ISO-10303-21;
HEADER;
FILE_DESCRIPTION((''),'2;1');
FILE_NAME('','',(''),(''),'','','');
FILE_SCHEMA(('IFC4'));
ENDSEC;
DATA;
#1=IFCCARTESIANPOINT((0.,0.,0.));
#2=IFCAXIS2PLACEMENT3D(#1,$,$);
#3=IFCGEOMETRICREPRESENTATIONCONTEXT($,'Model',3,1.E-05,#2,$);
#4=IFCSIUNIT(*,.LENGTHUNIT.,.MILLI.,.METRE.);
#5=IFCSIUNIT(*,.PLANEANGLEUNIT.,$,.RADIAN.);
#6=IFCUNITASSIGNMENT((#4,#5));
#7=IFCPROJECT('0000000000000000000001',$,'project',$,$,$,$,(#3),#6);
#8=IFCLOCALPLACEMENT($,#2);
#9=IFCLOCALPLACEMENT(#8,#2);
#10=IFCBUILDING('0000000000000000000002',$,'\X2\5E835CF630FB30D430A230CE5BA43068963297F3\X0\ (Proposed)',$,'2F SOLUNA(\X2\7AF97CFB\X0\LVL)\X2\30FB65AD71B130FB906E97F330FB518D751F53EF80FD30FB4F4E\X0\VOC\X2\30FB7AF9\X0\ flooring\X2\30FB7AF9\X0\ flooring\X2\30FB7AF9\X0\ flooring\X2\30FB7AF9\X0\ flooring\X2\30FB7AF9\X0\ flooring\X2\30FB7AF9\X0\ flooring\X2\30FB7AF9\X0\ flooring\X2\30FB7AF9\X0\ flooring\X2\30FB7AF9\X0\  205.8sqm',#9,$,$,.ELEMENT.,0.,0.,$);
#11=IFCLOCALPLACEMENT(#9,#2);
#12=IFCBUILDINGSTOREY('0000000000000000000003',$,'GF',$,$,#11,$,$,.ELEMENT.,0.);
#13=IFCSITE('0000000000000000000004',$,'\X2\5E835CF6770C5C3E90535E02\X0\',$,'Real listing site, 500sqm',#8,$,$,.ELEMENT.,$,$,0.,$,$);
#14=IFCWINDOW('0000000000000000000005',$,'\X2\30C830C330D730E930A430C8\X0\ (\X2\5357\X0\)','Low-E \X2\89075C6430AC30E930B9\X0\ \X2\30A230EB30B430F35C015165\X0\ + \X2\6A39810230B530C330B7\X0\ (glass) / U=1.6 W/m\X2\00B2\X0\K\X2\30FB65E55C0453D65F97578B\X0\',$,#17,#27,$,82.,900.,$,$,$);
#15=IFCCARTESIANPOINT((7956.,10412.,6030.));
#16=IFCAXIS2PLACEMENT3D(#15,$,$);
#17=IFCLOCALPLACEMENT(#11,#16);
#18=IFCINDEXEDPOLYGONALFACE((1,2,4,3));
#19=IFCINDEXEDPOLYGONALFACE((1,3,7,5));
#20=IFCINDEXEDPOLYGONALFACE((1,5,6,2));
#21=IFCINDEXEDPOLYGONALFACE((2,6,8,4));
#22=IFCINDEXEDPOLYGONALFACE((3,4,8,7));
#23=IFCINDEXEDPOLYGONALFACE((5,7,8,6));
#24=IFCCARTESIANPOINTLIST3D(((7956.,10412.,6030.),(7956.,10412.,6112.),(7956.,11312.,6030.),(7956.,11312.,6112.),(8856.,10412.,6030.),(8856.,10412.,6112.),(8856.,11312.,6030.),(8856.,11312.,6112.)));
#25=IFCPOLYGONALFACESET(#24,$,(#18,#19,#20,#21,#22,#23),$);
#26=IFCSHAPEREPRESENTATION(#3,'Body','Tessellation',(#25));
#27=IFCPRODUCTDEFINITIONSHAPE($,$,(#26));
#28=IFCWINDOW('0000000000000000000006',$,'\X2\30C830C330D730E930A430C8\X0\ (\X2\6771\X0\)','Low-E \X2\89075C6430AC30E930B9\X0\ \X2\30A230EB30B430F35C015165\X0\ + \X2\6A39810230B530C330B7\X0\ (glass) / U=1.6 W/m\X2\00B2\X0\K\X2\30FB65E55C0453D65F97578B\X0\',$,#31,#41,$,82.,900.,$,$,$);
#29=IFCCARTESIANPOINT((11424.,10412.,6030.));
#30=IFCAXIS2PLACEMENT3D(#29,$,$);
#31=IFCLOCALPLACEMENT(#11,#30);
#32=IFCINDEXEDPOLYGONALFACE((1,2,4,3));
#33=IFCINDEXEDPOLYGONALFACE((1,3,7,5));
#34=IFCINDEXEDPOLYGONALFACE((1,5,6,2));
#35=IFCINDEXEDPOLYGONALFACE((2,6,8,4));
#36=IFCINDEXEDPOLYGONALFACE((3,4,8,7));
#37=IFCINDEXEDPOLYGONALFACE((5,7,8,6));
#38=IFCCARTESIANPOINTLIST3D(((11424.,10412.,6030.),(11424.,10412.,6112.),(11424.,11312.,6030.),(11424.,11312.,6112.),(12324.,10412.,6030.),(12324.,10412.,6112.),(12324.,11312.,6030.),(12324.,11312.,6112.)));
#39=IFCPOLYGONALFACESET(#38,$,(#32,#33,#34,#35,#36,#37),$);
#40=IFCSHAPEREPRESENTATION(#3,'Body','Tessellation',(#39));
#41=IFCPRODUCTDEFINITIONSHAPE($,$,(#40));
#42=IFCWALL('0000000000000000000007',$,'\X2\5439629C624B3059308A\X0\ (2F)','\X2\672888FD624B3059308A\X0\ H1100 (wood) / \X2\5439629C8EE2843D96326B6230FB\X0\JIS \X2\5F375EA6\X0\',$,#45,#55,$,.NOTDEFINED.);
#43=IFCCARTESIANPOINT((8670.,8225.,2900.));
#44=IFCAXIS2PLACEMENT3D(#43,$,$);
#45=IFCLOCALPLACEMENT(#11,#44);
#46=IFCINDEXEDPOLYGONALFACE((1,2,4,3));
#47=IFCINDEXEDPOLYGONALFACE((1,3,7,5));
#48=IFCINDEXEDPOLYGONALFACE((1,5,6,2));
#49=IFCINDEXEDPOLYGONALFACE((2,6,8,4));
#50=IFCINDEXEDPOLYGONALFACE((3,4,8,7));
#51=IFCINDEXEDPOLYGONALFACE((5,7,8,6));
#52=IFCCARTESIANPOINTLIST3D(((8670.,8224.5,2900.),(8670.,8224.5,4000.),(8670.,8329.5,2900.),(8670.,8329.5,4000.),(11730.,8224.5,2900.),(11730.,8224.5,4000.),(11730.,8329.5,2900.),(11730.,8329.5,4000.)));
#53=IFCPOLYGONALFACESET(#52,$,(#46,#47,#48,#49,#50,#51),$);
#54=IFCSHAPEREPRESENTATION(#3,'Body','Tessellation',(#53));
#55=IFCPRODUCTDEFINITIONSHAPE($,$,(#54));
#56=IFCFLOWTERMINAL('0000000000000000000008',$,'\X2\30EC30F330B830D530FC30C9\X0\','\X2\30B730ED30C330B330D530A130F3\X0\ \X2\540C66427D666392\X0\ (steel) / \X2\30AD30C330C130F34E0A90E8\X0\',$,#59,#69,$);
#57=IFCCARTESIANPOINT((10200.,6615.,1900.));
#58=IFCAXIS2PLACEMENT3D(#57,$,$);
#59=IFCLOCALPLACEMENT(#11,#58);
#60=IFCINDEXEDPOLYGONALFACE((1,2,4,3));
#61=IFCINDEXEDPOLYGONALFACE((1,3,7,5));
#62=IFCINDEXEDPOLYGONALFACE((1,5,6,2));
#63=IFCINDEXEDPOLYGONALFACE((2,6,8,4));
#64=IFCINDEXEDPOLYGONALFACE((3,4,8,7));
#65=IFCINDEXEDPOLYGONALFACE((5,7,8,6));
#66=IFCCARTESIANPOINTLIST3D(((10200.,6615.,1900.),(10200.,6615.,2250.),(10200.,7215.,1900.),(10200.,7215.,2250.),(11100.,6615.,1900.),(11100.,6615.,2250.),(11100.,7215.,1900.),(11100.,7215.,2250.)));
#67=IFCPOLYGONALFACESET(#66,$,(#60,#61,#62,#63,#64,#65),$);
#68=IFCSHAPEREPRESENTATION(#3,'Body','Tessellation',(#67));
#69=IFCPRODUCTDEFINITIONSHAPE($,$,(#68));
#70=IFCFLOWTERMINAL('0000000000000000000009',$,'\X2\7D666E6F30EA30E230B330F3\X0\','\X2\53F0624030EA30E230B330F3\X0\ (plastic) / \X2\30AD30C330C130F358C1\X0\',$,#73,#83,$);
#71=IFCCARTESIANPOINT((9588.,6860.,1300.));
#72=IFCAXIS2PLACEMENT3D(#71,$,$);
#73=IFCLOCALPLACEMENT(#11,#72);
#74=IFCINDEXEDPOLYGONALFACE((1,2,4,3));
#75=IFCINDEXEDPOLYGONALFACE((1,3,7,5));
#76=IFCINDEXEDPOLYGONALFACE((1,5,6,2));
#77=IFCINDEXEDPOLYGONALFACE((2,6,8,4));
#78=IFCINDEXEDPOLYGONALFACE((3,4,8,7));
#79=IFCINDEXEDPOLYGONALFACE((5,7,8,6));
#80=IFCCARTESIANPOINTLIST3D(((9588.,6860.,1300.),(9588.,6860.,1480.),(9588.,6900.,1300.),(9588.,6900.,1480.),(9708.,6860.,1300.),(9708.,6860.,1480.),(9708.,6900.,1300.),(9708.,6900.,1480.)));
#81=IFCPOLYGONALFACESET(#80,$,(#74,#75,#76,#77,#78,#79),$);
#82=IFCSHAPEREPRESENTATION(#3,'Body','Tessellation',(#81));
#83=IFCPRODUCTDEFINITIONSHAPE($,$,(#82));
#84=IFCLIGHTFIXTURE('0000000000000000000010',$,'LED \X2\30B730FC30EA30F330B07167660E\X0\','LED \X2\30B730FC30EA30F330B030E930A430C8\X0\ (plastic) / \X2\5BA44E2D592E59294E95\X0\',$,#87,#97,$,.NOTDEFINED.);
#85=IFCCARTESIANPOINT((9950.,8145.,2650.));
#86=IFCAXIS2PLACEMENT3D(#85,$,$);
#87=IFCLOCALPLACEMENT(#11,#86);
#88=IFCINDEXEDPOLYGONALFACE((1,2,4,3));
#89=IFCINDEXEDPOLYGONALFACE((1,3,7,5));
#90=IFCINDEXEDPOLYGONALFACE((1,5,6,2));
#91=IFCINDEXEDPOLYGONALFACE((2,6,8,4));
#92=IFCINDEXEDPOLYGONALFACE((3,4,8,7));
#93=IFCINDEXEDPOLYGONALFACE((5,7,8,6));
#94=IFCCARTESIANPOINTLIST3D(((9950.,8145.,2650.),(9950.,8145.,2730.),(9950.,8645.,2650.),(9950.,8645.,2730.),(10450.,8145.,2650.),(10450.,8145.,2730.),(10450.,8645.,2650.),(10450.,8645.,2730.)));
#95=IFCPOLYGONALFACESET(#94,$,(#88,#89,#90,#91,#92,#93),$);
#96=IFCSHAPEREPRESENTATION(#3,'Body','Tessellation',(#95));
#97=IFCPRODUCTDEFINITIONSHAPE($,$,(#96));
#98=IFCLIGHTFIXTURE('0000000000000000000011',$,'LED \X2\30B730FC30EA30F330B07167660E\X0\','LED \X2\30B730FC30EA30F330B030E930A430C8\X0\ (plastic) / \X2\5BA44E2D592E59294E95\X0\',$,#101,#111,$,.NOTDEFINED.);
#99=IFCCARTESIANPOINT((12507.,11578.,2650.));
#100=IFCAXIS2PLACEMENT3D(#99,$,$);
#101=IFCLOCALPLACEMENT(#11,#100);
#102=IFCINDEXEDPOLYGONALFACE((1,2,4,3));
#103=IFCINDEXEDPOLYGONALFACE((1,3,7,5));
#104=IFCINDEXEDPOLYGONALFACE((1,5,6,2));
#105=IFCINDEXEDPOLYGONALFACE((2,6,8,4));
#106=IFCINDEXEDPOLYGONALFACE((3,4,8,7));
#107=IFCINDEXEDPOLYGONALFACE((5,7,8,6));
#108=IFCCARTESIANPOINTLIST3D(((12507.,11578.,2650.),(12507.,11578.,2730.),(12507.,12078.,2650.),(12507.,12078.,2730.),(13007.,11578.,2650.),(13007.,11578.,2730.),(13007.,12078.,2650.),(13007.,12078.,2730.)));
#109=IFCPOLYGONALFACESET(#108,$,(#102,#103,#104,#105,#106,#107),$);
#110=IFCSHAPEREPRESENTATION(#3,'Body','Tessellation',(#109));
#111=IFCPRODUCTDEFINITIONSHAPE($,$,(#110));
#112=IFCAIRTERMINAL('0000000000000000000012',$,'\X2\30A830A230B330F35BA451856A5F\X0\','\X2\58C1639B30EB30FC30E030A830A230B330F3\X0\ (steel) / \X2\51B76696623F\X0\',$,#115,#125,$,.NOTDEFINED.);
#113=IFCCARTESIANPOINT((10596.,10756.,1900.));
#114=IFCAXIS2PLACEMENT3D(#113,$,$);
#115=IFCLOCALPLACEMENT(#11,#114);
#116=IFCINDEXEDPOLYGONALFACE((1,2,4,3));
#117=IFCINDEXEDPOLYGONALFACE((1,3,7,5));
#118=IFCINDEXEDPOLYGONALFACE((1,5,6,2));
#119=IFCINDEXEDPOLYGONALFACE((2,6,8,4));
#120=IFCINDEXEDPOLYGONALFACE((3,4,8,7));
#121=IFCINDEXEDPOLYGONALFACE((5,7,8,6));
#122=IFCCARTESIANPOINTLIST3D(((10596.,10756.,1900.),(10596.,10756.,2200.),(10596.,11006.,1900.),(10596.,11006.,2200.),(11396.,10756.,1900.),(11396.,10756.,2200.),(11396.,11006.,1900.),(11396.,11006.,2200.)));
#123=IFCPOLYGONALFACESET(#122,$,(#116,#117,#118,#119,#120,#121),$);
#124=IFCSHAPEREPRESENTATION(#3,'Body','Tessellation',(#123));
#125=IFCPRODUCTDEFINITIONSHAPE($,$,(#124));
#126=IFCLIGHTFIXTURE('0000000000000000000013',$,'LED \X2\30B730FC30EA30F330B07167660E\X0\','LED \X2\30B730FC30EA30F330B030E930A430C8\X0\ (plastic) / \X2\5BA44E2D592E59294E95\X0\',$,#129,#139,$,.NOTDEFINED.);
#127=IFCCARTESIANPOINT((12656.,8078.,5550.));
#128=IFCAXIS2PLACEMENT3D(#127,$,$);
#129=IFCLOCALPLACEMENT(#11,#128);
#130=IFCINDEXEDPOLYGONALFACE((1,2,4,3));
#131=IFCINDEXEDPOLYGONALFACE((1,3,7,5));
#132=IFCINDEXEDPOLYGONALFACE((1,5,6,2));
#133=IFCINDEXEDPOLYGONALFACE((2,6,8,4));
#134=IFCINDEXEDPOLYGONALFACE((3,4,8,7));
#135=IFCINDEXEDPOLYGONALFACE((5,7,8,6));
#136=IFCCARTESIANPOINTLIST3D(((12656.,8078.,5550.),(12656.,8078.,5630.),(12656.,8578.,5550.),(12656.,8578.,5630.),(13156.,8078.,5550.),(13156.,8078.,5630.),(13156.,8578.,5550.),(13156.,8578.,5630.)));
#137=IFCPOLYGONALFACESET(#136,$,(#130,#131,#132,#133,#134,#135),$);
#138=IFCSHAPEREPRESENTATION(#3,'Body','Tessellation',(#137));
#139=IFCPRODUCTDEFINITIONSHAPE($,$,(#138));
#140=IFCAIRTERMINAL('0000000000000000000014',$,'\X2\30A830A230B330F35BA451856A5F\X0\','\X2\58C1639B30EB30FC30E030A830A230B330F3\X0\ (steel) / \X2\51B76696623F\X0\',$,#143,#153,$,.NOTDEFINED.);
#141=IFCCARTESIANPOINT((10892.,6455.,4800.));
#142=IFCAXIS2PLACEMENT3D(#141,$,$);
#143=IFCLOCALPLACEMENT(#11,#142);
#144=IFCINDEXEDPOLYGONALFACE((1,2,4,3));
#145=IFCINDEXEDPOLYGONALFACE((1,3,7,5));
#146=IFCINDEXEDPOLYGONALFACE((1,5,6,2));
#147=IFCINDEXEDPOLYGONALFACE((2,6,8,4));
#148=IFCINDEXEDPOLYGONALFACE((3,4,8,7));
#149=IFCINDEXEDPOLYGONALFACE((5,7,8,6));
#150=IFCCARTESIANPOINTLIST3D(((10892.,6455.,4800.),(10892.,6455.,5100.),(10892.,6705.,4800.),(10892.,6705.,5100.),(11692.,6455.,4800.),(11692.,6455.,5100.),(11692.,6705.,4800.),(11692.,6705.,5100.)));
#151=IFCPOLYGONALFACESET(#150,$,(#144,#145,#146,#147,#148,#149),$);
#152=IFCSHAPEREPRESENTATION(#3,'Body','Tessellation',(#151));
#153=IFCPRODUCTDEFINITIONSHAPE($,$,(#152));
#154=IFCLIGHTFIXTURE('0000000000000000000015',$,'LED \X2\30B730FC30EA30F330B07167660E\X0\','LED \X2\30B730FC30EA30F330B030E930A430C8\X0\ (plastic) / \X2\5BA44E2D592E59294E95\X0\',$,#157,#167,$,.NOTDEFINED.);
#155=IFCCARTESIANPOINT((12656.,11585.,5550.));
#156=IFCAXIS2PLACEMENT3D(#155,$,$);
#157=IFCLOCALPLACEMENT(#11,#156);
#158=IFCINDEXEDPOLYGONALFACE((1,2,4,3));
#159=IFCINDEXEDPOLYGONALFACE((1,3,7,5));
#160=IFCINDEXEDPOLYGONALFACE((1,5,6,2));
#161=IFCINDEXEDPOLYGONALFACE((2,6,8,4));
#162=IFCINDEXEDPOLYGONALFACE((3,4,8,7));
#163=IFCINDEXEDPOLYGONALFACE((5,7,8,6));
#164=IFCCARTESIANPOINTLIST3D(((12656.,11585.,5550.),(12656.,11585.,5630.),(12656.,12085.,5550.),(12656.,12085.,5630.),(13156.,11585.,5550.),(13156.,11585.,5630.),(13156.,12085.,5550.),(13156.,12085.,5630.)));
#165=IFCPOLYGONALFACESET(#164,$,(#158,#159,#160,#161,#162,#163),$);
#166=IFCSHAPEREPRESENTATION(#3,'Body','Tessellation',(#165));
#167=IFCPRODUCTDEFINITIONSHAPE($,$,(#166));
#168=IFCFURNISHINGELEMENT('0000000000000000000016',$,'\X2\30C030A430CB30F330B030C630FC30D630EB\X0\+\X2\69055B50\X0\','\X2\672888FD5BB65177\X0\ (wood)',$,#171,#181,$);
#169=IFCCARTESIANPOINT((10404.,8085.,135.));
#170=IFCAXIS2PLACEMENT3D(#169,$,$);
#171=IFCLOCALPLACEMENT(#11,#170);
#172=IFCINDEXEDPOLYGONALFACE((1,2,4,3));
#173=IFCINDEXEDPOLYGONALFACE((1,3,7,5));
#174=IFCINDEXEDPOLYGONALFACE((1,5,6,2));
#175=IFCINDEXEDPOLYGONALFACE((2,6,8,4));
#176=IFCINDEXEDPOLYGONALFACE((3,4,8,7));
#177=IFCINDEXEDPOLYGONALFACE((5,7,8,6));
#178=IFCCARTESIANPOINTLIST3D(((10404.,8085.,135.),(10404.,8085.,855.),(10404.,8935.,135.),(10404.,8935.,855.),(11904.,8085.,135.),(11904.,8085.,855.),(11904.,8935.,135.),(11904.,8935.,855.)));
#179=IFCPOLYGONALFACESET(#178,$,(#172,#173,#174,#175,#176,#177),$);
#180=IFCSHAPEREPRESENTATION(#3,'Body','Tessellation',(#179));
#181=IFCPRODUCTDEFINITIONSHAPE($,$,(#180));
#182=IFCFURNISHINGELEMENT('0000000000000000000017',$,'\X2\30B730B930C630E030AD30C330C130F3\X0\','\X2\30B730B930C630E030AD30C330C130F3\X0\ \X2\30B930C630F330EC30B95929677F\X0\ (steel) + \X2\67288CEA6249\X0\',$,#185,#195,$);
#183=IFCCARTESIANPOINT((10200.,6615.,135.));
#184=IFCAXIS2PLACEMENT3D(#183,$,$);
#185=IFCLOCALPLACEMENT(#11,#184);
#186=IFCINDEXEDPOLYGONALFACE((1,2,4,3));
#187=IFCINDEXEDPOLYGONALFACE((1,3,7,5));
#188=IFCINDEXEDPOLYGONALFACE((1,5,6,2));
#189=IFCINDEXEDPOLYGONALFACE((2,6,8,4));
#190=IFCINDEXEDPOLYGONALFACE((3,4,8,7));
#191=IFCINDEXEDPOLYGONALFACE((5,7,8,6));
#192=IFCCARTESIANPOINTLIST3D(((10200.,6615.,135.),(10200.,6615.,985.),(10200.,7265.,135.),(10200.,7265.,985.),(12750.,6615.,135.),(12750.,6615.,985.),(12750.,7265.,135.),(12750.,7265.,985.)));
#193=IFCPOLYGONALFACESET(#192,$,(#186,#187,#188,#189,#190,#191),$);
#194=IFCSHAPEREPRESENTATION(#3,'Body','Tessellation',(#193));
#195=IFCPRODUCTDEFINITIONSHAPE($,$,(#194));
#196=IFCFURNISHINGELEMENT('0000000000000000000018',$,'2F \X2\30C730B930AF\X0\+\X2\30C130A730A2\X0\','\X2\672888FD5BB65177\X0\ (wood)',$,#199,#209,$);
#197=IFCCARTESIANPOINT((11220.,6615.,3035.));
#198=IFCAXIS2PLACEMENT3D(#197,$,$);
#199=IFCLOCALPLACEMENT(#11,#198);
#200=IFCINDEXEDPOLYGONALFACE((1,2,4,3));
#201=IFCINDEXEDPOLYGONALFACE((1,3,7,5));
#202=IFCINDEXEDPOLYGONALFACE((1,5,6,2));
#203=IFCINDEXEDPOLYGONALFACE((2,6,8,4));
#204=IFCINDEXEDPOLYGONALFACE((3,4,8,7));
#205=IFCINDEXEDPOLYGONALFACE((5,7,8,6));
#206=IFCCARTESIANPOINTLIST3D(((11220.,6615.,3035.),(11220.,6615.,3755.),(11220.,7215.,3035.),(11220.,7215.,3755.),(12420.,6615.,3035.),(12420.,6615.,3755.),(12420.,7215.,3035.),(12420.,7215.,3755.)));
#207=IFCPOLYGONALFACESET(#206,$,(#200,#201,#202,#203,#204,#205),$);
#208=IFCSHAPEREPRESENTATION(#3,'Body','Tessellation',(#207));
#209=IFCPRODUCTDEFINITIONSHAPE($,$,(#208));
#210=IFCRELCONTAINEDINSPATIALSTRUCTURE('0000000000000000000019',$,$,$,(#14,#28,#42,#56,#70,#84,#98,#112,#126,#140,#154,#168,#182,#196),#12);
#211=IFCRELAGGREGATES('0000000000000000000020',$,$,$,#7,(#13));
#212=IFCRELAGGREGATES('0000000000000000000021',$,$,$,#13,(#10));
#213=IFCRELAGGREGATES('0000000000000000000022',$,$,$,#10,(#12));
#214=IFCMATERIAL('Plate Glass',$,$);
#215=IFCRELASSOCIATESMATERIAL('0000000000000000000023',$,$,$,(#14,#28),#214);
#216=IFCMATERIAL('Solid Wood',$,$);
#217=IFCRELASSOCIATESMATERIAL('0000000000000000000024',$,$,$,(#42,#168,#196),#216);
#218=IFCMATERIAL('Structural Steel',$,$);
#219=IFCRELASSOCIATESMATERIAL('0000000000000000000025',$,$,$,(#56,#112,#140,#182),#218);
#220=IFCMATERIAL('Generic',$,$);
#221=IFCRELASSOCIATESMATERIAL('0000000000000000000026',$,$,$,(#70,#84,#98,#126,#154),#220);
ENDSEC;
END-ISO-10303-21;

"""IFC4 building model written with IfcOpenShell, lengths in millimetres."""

from ifc_helpers import new_model, si_unit, frame, frame_2d, origin, place, context, project, spatial, rectangle, extrude, material, element, save


model = new_model("IFC4")

# Units and contexts
model_context = context("Model", 3, precision=1e-05, world=origin())
ifc_project = project(units=[si_unit("LENGTHUNIT", "METRE", prefix="MILLI"), si_unit("PLANEANGLEUNIT", "RADIAN")], contexts=[model_context])

# Site, building, storey
site_placement = place(None, origin())
site = spatial("IfcSite", under=ifc_project, at=site_placement, Name="広島県尾道市", ObjectType="Real listing site, 500sqm", CompositionType="ELEMENT", RefElevation=0.0)
building_placement = place(site_placement, origin())
building = spatial("IfcBuilding", under=site, at=building_placement, Name="広島・ピアノ室と防音 (Proposed)", ObjectType="2F SOLUNA(竹系LVL)・断熱・遮音・再生可能・低VOC・竹 flooring・竹 flooring・竹 flooring・竹 flooring・竹 flooring・竹 flooring・竹 flooring・竹 flooring・竹  205.8sqm", CompositionType="ELEMENT", ElevationOfRefHeight=0.0, ElevationOfTerrain=0.0)
storey_placement = place(building_placement, origin())
storey = spatial("IfcBuildingStorey", under=building, at=storey_placement, Name="GF", CompositionType="ELEMENT", Elevation=0.0)

# Shared definitions
ifc_material_1 = material(Name="Solid Wood")

# Windows
ifc_material_2 = material(Name="Plate Glass")
window_1_placement = place(storey_placement, frame((7956.0, 10412.0, 6030.0)))
element("IfcWindow", 1, at=window_1_placement, inside=storey, material=ifc_material_2, Name="トップライト (南)", Description="Low-E 複層ガラス アルゴン封入 + 樹脂サッシ (glass) / U=1.6 W/m²K・日射取得型", OverallHeight=82.0, OverallWidth=900.0, context=model_context, shape_type="SweptSolid", body=[
    extrude(rectangle(XDim=900.0, YDim=900.0, at=frame_2d((450.0, 450.0))), frame((7956.0, 10412.0, 6030.0)), (0.0, 0.0, 1.0), 82.0),
])
window_2_placement = place(storey_placement, frame((11424.0, 10412.0, 6030.0)))
element("IfcWindow", 2, at=window_2_placement, inside=storey, material=ifc_material_2, Name="トップライト (東)", Description="Low-E 複層ガラス アルゴン封入 + 樹脂サッシ (glass) / U=1.6 W/m²K・日射取得型", OverallHeight=82.0, OverallWidth=900.0, context=model_context, shape_type="SweptSolid", body=[
    extrude(rectangle(XDim=900.0, YDim=900.0, at=frame_2d((450.0, 450.0))), frame((11424.0, 10412.0, 6030.0)), (0.0, 0.0, 1.0), 82.0),
])

# Wall
wall_1_placement = place(storey_placement, frame((8670.0, 8225.0, 2900.0)))
element("IfcWall", 3, at=wall_1_placement, inside=storey, material=ifc_material_1, Name="吹抜手すり (2F)", Description="木製手すり H1100 (wood) / 吹抜転落防止・JIS 強度", PredefinedType="NOTDEFINED", context=model_context, shape_type="SweptSolid", body=[
    extrude(rectangle(XDim=3060.0, YDim=105.0, at=frame_2d((1530.0, 52.0))), frame((8670.0, 8225.0, 2900.0)), (0.0, 0.0, 1.0), 1100.0),
])

# Flow terminals
ifc_material_3 = material(Name="Structural Steel")
flow_terminal_1_placement = place(storey_placement, frame((10200.0, 6615.0, 1900.0)))
element("IfcFlowTerminal", 4, at=flow_terminal_1_placement, inside=storey, material=ifc_material_3, Name="レンジフード", Description="シロッコファン 同時給排 (steel) / キッチン上部", context=model_context, shape_type="SweptSolid", body=[
    extrude(rectangle(XDim=900.0, YDim=600.0, at=frame_2d((450.0, 300.0))), frame((10200.0, 6615.0, 1900.0)), (0.0, 0.0, 1.0), 350.0),
])
ifc_material_4 = material(Name="Generic")
flow_terminal_2_placement = place(storey_placement, frame((9588.0, 6860.0, 1300.0)))
element("IfcFlowTerminal", 5, at=flow_terminal_2_placement, inside=storey, material=ifc_material_4, Name="給湯リモコン", Description="台所リモコン (plastic) / キッチン壁", context=model_context, shape_type="SweptSolid", body=[
    extrude(rectangle(XDim=120.0, YDim=40.0, at=frame_2d((60.0, 20.0))), frame((9588.0, 6860.0, 1300.0)), (0.0, 0.0, 1.0), 180.0),
])

# Light fixtures
light_fixture_1_placement = place(storey_placement, frame((9950.0, 8145.0, 2650.0)))
element("IfcLightFixture", 6, at=light_fixture_1_placement, inside=storey, material=ifc_material_4, Name="LED シーリング照明", Description="LED シーリングライト (plastic) / 室中央天井", PredefinedType="NOTDEFINED", context=model_context, shape_type="SweptSolid", body=[
    extrude(rectangle(XDim=500.0, YDim=500.0, at=frame_2d((250.0, 250.0))), frame((9950.0, 8145.0, 2650.0)), (0.0, 0.0, 1.0), 80.0),
])
light_fixture_2_placement = place(storey_placement, frame((12507.0, 11578.0, 2650.0)))
element("IfcLightFixture", 7, at=light_fixture_2_placement, inside=storey, material=ifc_material_4, Name="LED シーリング照明", Description="LED シーリングライト (plastic) / 室中央天井", PredefinedType="NOTDEFINED", context=model_context, shape_type="SweptSolid", body=[
    extrude(rectangle(XDim=500.0, YDim=500.0, at=frame_2d((250.0, 250.0))), frame((12507.0, 11578.0, 2650.0)), (0.0, 0.0, 1.0), 80.0),
])

# Air terminal
air_terminal_1_placement = place(storey_placement, frame((10596.0, 10756.0, 1900.0)))
element("IfcAirTerminal", 8, at=air_terminal_1_placement, inside=storey, material=ifc_material_3, Name="エアコン室内機", Description="壁掛ルームエアコン (steel) / 冷暖房", PredefinedType="NOTDEFINED", context=model_context, shape_type="SweptSolid", body=[
    extrude(rectangle(XDim=800.0, YDim=250.0, at=frame_2d((400.0, 125.0))), frame((10596.0, 10756.0, 1900.0)), (0.0, 0.0, 1.0), 300.0),
])

# Light fixture
light_fixture_3_placement = place(storey_placement, frame((12656.0, 8078.0, 5550.0)))
element("IfcLightFixture", 9, at=light_fixture_3_placement, inside=storey, material=ifc_material_4, Name="LED シーリング照明", Description="LED シーリングライト (plastic) / 室中央天井", PredefinedType="NOTDEFINED", context=model_context, shape_type="SweptSolid", body=[
    extrude(rectangle(XDim=500.0, YDim=500.0, at=frame_2d((250.0, 250.0))), frame((12656.0, 8078.0, 5550.0)), (0.0, 0.0, 1.0), 80.0),
])

# Air terminal
air_terminal_2_placement = place(storey_placement, frame((10892.0, 6455.0, 4800.0)))
element("IfcAirTerminal", 10, at=air_terminal_2_placement, inside=storey, material=ifc_material_3, Name="エアコン室内機", Description="壁掛ルームエアコン (steel) / 冷暖房", PredefinedType="NOTDEFINED", context=model_context, shape_type="SweptSolid", body=[
    extrude(rectangle(XDim=800.0, YDim=250.0, at=frame_2d((400.0, 125.0))), frame((10892.0, 6455.0, 4800.0)), (0.0, 0.0, 1.0), 300.0),
])

# Light fixture
light_fixture_4_placement = place(storey_placement, frame((12656.0, 11585.0, 5550.0)))
element("IfcLightFixture", 11, at=light_fixture_4_placement, inside=storey, material=ifc_material_4, Name="LED シーリング照明", Description="LED シーリングライト (plastic) / 室中央天井", PredefinedType="NOTDEFINED", context=model_context, shape_type="SweptSolid", body=[
    extrude(rectangle(XDim=500.0, YDim=500.0, at=frame_2d((250.0, 250.0))), frame((12656.0, 11585.0, 5550.0)), (0.0, 0.0, 1.0), 80.0),
])

# Furnishing elements
furnishing_1_placement = place(storey_placement, frame((10404.0, 8085.0, 135.0)))
element("IfcFurnishingElement", 12, at=furnishing_1_placement, inside=storey, material=ifc_material_1, Name="ダイニングテーブル+椅子", Description="木製家具 (wood)", context=model_context, shape_type="SweptSolid", body=[
    extrude(rectangle(XDim=1500.0, YDim=850.0, at=frame_2d((750.0, 425.0))), frame((10404.0, 8085.0, 135.0)), (0.0, 0.0, 1.0), 720.0),
])
furnishing_2_placement = place(storey_placement, frame((10200.0, 6615.0, 135.0)))
element("IfcFurnishingElement", 13, at=furnishing_2_placement, inside=storey, material=ifc_material_3, Name="システムキッチン", Description="システムキッチン ステンレス天板 (steel) + 木質扉", context=model_context, shape_type="SweptSolid", body=[
    extrude(rectangle(XDim=2550.0, YDim=650.0, at=frame_2d((1275.0, 325.0))), frame((10200.0, 6615.0, 135.0)), (0.0, 0.0, 1.0), 850.0),
])
furnishing_3_placement = place(storey_placement, frame((11220.0, 6615.0, 3035.0)))
element("IfcFurnishingElement", 14, at=furnishing_3_placement, inside=storey, material=ifc_material_1, Name="2F デスク+チェア", Description="木製家具 (wood)", context=model_context, shape_type="SweptSolid", body=[
    extrude(rectangle(XDim=1200.0, YDim=600.0, at=frame_2d((600.0, 300.0))), frame((11220.0, 6615.0, 3035.0)), (0.0, 0.0, 1.0), 720.0),
])

save(model, "model.ifc")
